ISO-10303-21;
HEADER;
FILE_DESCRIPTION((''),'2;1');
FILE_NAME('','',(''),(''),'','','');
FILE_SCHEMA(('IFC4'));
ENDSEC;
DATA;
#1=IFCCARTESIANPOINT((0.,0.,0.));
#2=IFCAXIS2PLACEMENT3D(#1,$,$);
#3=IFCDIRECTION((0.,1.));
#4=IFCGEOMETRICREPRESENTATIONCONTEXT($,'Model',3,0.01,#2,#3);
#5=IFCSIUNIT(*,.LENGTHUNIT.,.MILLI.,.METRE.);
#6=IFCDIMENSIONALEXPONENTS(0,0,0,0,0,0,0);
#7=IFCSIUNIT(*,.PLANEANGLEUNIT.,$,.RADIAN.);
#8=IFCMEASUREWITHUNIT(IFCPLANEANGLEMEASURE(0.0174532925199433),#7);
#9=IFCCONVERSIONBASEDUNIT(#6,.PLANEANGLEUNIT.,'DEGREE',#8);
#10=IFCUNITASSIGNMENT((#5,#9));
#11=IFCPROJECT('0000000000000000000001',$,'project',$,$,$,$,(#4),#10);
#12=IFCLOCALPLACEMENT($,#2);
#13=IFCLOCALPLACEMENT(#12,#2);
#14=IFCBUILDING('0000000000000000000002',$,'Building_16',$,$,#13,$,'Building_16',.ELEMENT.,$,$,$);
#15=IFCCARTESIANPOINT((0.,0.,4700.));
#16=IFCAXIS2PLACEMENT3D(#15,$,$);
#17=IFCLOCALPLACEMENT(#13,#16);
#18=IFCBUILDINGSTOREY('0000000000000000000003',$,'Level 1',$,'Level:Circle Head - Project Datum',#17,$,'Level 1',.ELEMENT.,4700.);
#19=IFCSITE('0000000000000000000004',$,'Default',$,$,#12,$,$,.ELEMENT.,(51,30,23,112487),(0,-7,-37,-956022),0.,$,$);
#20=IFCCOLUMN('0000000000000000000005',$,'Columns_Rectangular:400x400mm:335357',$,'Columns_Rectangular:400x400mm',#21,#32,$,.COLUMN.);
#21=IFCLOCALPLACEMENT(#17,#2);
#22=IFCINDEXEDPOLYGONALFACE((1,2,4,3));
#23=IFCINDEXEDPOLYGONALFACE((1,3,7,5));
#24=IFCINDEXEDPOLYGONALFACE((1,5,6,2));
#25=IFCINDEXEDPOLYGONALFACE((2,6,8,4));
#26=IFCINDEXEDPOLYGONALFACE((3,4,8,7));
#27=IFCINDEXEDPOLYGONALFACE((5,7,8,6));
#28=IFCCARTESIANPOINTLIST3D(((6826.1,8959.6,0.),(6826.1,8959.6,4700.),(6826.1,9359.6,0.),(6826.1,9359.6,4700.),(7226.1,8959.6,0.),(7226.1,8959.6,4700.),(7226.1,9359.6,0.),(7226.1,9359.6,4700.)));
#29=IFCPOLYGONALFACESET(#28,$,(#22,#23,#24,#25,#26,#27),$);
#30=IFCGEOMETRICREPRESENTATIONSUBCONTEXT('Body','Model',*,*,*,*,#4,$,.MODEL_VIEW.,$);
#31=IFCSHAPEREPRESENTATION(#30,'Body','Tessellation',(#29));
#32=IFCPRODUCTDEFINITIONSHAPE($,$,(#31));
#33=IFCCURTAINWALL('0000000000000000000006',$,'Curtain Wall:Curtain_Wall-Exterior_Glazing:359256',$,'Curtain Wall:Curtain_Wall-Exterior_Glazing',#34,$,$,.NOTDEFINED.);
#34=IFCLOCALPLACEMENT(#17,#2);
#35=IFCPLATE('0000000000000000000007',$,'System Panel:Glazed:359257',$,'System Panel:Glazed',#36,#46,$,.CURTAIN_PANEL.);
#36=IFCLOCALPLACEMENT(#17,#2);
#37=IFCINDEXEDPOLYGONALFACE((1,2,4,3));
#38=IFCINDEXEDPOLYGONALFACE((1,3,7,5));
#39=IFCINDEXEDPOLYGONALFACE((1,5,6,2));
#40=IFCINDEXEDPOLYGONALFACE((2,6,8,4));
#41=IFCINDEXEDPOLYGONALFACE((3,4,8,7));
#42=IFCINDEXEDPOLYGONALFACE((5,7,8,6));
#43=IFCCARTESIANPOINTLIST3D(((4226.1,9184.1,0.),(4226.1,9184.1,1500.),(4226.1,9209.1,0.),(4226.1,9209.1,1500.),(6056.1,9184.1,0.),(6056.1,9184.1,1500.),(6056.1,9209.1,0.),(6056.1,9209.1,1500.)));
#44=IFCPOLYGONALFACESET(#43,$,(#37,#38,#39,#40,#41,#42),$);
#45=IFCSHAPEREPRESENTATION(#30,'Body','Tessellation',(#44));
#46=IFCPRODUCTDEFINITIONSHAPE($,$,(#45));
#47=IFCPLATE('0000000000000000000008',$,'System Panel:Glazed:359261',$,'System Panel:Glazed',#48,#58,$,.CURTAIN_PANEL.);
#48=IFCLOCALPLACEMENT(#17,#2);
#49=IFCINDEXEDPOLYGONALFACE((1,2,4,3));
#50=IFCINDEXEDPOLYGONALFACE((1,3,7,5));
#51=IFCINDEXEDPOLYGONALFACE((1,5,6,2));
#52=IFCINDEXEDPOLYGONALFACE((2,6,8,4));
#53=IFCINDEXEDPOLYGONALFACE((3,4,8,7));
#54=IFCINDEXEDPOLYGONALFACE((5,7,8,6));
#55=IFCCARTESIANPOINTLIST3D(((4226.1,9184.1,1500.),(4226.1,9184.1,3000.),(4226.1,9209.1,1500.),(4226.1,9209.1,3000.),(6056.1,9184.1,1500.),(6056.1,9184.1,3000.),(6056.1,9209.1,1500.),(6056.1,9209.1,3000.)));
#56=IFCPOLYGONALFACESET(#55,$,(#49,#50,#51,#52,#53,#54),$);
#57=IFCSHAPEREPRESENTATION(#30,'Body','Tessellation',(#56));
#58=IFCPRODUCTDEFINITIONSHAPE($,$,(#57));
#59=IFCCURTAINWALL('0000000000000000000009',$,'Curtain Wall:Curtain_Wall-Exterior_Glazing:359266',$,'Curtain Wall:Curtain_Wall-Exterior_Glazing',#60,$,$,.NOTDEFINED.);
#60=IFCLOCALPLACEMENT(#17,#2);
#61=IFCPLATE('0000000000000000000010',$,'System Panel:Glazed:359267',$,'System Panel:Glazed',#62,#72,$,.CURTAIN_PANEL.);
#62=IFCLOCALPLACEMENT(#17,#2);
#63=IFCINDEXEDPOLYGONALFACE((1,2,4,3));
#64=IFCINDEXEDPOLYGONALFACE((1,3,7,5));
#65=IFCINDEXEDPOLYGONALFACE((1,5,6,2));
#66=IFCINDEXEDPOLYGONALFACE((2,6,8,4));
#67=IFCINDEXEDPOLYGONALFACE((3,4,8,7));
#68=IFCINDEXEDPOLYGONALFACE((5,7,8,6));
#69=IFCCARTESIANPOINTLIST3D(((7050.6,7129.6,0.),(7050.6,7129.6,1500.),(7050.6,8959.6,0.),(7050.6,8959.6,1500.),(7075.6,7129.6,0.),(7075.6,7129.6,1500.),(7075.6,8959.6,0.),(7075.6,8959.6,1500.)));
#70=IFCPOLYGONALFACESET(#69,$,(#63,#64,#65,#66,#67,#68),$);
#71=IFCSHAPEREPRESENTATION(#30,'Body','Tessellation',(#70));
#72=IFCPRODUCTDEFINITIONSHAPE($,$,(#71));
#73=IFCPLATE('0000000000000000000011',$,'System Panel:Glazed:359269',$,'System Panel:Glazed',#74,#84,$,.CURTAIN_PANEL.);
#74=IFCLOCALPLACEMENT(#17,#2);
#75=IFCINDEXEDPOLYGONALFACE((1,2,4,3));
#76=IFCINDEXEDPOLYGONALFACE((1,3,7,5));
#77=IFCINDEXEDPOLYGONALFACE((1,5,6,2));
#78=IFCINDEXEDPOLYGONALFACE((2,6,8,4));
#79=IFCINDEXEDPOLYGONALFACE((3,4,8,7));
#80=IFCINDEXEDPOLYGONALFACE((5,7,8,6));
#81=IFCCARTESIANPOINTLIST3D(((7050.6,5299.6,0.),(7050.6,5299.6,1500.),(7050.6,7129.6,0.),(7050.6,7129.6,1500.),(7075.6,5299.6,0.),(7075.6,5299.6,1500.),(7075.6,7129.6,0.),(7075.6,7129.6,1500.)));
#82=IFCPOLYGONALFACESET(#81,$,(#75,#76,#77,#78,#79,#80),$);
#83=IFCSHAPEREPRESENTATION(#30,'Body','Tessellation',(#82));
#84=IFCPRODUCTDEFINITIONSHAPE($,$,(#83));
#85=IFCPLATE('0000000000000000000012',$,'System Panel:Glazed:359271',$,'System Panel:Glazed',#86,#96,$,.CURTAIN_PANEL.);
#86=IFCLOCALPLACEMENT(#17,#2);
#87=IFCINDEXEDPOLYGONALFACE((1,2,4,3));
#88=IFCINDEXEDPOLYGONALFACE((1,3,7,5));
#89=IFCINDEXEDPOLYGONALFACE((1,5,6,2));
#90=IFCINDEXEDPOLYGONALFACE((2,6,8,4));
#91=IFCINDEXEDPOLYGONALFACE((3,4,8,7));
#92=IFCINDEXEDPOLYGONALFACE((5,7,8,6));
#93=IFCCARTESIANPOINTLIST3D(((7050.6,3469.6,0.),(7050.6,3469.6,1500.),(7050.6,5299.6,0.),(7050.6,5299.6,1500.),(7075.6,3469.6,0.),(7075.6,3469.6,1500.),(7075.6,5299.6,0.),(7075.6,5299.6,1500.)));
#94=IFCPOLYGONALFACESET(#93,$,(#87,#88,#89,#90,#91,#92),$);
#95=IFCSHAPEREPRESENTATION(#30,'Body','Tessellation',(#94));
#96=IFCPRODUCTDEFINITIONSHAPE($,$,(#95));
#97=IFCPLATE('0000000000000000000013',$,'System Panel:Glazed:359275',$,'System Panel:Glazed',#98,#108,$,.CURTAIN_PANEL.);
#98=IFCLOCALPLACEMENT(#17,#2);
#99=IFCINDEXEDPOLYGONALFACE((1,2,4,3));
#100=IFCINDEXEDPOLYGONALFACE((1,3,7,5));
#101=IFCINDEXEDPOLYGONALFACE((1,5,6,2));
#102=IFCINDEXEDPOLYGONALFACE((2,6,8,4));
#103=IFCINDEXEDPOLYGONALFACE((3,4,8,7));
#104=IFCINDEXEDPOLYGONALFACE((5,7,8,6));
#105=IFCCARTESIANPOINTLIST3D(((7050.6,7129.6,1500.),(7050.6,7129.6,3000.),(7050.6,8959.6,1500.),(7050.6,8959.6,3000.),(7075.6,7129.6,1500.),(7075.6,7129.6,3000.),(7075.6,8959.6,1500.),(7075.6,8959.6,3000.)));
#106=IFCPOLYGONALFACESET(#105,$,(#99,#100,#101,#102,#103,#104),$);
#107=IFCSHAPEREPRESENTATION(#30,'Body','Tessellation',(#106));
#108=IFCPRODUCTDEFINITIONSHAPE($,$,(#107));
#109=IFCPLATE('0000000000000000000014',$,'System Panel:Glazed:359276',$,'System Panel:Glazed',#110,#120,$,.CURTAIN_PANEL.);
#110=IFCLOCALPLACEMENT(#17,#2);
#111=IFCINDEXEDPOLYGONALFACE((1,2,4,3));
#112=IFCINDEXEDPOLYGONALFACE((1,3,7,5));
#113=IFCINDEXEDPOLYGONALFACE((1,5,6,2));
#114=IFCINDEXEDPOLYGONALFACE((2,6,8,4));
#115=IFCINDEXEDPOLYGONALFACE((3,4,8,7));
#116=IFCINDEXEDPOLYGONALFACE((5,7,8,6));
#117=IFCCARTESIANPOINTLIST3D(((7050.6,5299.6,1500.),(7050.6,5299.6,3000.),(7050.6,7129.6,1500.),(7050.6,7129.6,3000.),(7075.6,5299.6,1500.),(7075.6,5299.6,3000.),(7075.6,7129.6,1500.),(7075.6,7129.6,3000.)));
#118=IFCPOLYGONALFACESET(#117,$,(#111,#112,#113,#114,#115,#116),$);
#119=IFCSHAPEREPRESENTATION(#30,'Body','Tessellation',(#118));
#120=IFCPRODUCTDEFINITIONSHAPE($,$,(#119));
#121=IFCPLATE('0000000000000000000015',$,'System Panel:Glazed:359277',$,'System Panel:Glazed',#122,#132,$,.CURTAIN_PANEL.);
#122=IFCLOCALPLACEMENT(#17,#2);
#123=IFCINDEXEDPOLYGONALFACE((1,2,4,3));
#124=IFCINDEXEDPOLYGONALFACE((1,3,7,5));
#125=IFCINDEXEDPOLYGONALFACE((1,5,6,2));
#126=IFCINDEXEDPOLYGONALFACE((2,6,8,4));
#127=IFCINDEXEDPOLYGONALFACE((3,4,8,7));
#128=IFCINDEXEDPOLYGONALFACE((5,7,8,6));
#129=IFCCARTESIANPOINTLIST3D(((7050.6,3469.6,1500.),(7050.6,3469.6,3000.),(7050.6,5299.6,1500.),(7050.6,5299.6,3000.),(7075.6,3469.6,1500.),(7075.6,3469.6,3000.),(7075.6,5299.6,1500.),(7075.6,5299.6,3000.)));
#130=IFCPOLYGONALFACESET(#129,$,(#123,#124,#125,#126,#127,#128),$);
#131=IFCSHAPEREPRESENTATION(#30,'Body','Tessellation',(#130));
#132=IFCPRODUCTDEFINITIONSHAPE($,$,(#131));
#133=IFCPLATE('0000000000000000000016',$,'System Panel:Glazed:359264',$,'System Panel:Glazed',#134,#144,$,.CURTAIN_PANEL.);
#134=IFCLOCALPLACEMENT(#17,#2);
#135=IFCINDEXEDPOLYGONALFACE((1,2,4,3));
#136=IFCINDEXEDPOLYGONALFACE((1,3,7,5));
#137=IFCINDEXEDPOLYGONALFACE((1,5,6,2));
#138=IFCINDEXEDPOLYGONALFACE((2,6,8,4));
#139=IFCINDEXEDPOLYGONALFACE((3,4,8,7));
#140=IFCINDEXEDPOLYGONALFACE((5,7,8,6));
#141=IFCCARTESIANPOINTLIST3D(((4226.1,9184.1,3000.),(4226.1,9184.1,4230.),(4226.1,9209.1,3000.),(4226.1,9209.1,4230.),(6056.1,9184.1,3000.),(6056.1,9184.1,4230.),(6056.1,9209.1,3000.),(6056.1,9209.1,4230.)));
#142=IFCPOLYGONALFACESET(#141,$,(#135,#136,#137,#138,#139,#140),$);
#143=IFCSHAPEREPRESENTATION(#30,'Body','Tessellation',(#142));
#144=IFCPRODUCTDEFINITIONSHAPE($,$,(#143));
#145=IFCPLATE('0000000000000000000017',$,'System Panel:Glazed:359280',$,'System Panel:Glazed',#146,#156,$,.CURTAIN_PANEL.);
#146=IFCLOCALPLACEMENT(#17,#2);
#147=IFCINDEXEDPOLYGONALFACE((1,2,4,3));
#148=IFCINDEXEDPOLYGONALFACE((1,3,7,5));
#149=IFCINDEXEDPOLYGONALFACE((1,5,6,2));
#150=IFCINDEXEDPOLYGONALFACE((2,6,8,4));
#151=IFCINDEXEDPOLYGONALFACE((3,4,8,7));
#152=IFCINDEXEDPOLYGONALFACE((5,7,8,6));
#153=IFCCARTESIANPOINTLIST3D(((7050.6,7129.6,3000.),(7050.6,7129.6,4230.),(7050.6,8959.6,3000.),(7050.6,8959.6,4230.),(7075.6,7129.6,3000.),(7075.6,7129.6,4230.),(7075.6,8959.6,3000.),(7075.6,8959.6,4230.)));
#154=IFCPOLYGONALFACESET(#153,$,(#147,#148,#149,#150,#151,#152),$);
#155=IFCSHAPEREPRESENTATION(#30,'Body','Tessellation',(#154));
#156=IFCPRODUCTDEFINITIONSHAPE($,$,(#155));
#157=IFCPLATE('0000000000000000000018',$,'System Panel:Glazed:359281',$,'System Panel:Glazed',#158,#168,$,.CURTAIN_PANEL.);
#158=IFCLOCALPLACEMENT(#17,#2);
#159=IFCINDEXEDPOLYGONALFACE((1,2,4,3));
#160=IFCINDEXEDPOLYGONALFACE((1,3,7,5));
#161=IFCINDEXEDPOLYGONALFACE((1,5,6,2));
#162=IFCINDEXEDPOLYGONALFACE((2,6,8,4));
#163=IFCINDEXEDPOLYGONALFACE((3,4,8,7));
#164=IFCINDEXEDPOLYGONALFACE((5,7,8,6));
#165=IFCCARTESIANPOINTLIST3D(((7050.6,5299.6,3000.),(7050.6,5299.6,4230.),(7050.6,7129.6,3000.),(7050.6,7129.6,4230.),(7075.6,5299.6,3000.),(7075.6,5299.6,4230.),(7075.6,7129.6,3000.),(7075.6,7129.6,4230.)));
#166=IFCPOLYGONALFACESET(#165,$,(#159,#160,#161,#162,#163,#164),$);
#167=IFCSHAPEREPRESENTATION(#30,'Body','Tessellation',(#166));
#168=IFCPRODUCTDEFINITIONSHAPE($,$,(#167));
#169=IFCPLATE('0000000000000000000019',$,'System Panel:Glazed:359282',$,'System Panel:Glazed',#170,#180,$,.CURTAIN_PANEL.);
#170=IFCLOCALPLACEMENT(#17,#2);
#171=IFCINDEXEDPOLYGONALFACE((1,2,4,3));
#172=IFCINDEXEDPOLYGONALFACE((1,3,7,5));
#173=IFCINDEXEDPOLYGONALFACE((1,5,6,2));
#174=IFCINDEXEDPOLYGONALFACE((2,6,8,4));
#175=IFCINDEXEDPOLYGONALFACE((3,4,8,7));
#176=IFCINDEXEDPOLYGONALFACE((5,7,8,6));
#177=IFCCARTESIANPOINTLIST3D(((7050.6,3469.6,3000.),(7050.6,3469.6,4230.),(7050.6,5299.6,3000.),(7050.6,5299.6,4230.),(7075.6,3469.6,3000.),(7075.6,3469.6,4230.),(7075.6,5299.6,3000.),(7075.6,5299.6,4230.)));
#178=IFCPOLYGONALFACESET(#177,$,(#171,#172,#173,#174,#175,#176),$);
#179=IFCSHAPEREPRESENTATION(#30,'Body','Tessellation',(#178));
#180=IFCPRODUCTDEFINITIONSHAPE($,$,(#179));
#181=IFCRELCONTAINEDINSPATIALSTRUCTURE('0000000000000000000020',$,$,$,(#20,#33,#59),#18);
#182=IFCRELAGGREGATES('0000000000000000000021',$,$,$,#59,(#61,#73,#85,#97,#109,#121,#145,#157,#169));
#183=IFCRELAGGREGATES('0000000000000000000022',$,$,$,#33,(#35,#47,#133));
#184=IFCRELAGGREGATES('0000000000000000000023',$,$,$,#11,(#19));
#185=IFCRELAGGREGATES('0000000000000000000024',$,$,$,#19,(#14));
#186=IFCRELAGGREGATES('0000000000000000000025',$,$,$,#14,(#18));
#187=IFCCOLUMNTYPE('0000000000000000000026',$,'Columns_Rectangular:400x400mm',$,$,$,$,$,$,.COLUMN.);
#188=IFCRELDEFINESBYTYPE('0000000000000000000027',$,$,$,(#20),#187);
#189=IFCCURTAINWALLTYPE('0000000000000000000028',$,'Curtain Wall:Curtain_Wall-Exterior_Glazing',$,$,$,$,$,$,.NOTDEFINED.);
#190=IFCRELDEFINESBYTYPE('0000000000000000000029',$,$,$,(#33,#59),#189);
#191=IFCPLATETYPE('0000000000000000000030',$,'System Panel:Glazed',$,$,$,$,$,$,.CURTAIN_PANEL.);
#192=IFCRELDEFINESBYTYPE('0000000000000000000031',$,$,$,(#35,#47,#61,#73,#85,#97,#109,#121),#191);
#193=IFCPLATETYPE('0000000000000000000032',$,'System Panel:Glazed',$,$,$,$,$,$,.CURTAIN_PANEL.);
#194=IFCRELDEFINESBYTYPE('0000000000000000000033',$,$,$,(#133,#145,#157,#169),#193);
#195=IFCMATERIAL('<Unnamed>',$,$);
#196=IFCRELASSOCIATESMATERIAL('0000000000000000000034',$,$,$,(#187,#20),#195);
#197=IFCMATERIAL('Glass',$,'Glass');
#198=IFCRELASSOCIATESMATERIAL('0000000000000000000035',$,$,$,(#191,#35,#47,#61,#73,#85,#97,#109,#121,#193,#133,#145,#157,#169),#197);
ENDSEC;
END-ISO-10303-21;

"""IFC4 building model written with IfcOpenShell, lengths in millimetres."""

from ifc_helpers import new_model, entity, si_unit, converted_unit, direction, frame, origin, place, context, subcontext, project, spatial, indexed_curve, outline, extrude, source, transform, mapped, material, type_object, type_shapes, element, aggregate, save


model = new_model("IFC4")

# Units and contexts
model_context = context("Model", 3, precision=0.01, world=origin(), true_north=direction((0.0, 1.0)))
body_context = subcontext(model_context, "Body", "Model", "MODEL_VIEW")
ifc_project = project(units=[si_unit("LENGTHUNIT", "METRE", prefix="MILLI"), converted_unit("PLANEANGLEUNIT", "DEGREE", entity("IfcPlaneAngleMeasure", 0.0174532925199433), si_unit("PLANEANGLEUNIT", "RADIAN"), dimensions=[0, 0, 0, 0, 0, 0, 0])], contexts=[model_context])

# Site, building, storey
site_placement = place(None, origin())
site = spatial("IfcSite", under=ifc_project, at=site_placement, Name="Default", CompositionType="ELEMENT", RefLatitude=(51, 30, 23, 112487), RefLongitude=(0, -7, -37, -956022), RefElevation=0.0)
building_placement = place(site_placement, origin())
building = spatial("IfcBuilding", under=site, at=building_placement, Name="Building_16", LongName="Building_16", CompositionType="ELEMENT")
storey_placement = place(building_placement, frame((0.0, 0.0, 4700.0)))
storey = spatial("IfcBuildingStorey", under=building, at=storey_placement, Name="Level 1", ObjectType="Level:Circle Head - Project Datum", LongName="Level 1", CompositionType="ELEMENT", Elevation=4700.0)

# Column
ifc_material_1 = material(Name="<Unnamed>")
column_type = type_object("IfcColumnType", Name="Columns_Rectangular:400x400mm", PredefinedType="COLUMN", material=ifc_material_1)
shared_shape_1 = source(origin(), body_context, "Body", "SweptSolid", [
    extrude(outline(indexed_curve([(-200.0, -200.0), (200.0, -200.0), (200.0, 200.0), (-200.0, 200.0), (-200.0, -200.0)], self_intersect=False)), frame((0.0, 0.0, 4700.0), z_axis=(0.0, 0.0, 1.0), x_axis=(-1.0, 0.0, 0.0)), (0.0, 0.0, 1.0), 4700.0),
])
type_shapes(column_type, [shared_shape_1])
column_placement = place(storey_placement, frame((7026.1, 9159.6, -4700.0)))
element("IfcColumn", 1, at=column_placement, inside=storey, type_object=column_type, material=ifc_material_1, Name="Columns_Rectangular:400x400mm:335357", ObjectType="Columns_Rectangular:400x400mm", PredefinedType="COLUMN", context=body_context, shape_type="MappedRepresentation", body=[
    mapped(shared_shape_1, transform((0.0, 0.0, 0.0), scale=1.0)),
])

# Curtain walls, plates
curtain_wall_type = type_object("IfcCurtainWallType", Name="Curtain Wall:Curtain_Wall-Exterior_Glazing", PredefinedType="NOTDEFINED")
curtain_wall_1_placement = place(storey_placement, frame((0.0, 0.0, -4700.0)))
curtain_wall_1 = element("IfcCurtainWall", 2, at=curtain_wall_1_placement, inside=storey, type_object=curtain_wall_type, Name="Curtain Wall:Curtain_Wall-Exterior_Glazing:359256", ObjectType="Curtain Wall:Curtain_Wall-Exterior_Glazing", PredefinedType="NOTDEFINED")
ifc_material_2 = material(Name="Glass", Category="Glass")
plate_type_1 = type_object("IfcPlateType", Name="System Panel:Glazed", PredefinedType="CURTAIN_PANEL", material=ifc_material_2)
shared_shape_2 = source(origin(), body_context, "Body", "SweptSolid", [
    extrude(outline(indexed_curve([(-12.5, -915.0), (12.5, -915.0), (12.5, 915.0), (-12.5, 915.0), (-12.5, -915.0)], self_intersect=False)), frame((0.0, 37.0, 0.0), z_axis=(0.0, 0.0, 1.0), x_axis=(0.0, 1.0, 0.0)), (0.0, 0.0, 1.0), 1500.0),
])
type_shapes(plate_type_1, [shared_shape_2])
plate_1_placement = place(curtain_wall_1_placement, frame((5141.1, 9159.6, 4700.0)))
plate_1 = element("IfcPlate", 3, at=plate_1_placement, type_object=plate_type_1, material=ifc_material_2, Name="System Panel:Glazed:359257", ObjectType="System Panel:Glazed", PredefinedType="CURTAIN_PANEL", context=body_context, shape_type="MappedRepresentation", body=[
    mapped(shared_shape_2, transform((0.0, 0.0, 0.0), scale=1.0)),
])
plate_2_placement = place(curtain_wall_1_placement, frame((5141.1, 9159.6, 6200.0)))
plate_2 = element("IfcPlate", 4, at=plate_2_placement, type_object=plate_type_1, material=ifc_material_2, Name="System Panel:Glazed:359261", ObjectType="System Panel:Glazed", PredefinedType="CURTAIN_PANEL", context=body_context, shape_type="MappedRepresentation", body=[
    mapped(shared_shape_2, transform((0.0, 0.0, 0.0), scale=1.0)),
])
curtain_wall_2_placement = place(storey_placement, frame((0.0, 0.0, -4700.0)))
curtain_wall_2 = element("IfcCurtainWall", 5, at=curtain_wall_2_placement, inside=storey, type_object=curtain_wall_type, Name="Curtain Wall:Curtain_Wall-Exterior_Glazing:359266", ObjectType="Curtain Wall:Curtain_Wall-Exterior_Glazing", PredefinedType="NOTDEFINED")
plate_3_placement = place(curtain_wall_2_placement, frame((7026.1, 8044.6, 4700.0), z_axis=(0.0, 0.0, 1.0), x_axis=(0.0, -1.0, 0.0)))
plate_3 = element("IfcPlate", 6, at=plate_3_placement, type_object=plate_type_1, material=ifc_material_2, Name="System Panel:Glazed:359267", ObjectType="System Panel:Glazed", PredefinedType="CURTAIN_PANEL", context=body_context, shape_type="MappedRepresentation", body=[
    mapped(shared_shape_2, transform((0.0, 0.0, 0.0), scale=1.0)),
])
plate_4_placement = place(curtain_wall_2_placement, frame((7026.1, 6214.6, 4700.0), z_axis=(0.0, 0.0, 1.0), x_axis=(0.0, -1.0, 0.0)))
plate_4 = element("IfcPlate", 7, at=plate_4_placement, type_object=plate_type_1, material=ifc_material_2, Name="System Panel:Glazed:359269", ObjectType="System Panel:Glazed", PredefinedType="CURTAIN_PANEL", context=body_context, shape_type="MappedRepresentation", body=[
    mapped(shared_shape_2, transform((0.0, 0.0, 0.0), scale=1.0)),
])
plate_5_placement = place(curtain_wall_2_placement, frame((7026.1, 4384.6, 4700.0), z_axis=(0.0, 0.0, 1.0), x_axis=(0.0, -1.0, 0.0)))
plate_5 = element("IfcPlate", 8, at=plate_5_placement, type_object=plate_type_1, material=ifc_material_2, Name="System Panel:Glazed:359271", ObjectType="System Panel:Glazed", PredefinedType="CURTAIN_PANEL", context=body_context, shape_type="MappedRepresentation", body=[
    mapped(shared_shape_2, transform((0.0, 0.0, 0.0), scale=1.0)),
])
plate_6_placement = place(curtain_wall_2_placement, frame((7026.1, 8044.6, 6200.0), z_axis=(0.0, 0.0, 1.0), x_axis=(0.0, -1.0, 0.0)))
plate_6 = element("IfcPlate", 9, at=plate_6_placement, type_object=plate_type_1, material=ifc_material_2, Name="System Panel:Glazed:359275", ObjectType="System Panel:Glazed", PredefinedType="CURTAIN_PANEL", context=body_context, shape_type="MappedRepresentation", body=[
    mapped(shared_shape_2, transform((0.0, 0.0, 0.0), scale=1.0)),
])
plate_7_placement = place(curtain_wall_2_placement, frame((7026.1, 6214.6, 6200.0), z_axis=(0.0, 0.0, 1.0), x_axis=(0.0, -1.0, 0.0)))
plate_7 = element("IfcPlate", 10, at=plate_7_placement, type_object=plate_type_1, material=ifc_material_2, Name="System Panel:Glazed:359276", ObjectType="System Panel:Glazed", PredefinedType="CURTAIN_PANEL", context=body_context, shape_type="MappedRepresentation", body=[
    mapped(shared_shape_2, transform((0.0, 0.0, 0.0), scale=1.0)),
])
plate_8_placement = place(curtain_wall_2_placement, frame((7026.1, 4384.6, 6200.0), z_axis=(0.0, 0.0, 1.0), x_axis=(0.0, -1.0, 0.0)))
plate_8 = element("IfcPlate", 11, at=plate_8_placement, type_object=plate_type_1, material=ifc_material_2, Name="System Panel:Glazed:359277", ObjectType="System Panel:Glazed", PredefinedType="CURTAIN_PANEL", context=body_context, shape_type="MappedRepresentation", body=[
    mapped(shared_shape_2, transform((0.0, 0.0, 0.0), scale=1.0)),
])

# Plates
plate_type_2 = type_object("IfcPlateType", Name="System Panel:Glazed", PredefinedType="CURTAIN_PANEL", material=ifc_material_2)
shared_shape_3 = source(origin(), body_context, "Body", "SweptSolid", [
    extrude(outline(indexed_curve([(-12.5, -915.0), (12.5, -915.0), (12.5, 915.0), (-12.5, 915.0), (-12.5, -915.0)], self_intersect=False)), frame((0.0, 37.0, 0.0), z_axis=(0.0, 0.0, 1.0), x_axis=(0.0, 1.0, 0.0)), (0.0, 0.0, 1.0), 1230.0),
])
type_shapes(plate_type_2, [shared_shape_3])
plate_9_placement = place(curtain_wall_1_placement, frame((5141.1, 9159.6, 7700.0)))
plate_9 = element("IfcPlate", 12, at=plate_9_placement, type_object=plate_type_2, material=ifc_material_2, Name="System Panel:Glazed:359264", ObjectType="System Panel:Glazed", PredefinedType="CURTAIN_PANEL", context=body_context, shape_type="MappedRepresentation", body=[
    mapped(shared_shape_3, transform((0.0, 0.0, 0.0), scale=1.0)),
])
plate_10_placement = place(curtain_wall_2_placement, frame((7026.1, 8044.6, 7700.0), z_axis=(0.0, 0.0, 1.0), x_axis=(0.0, -1.0, 0.0)))
plate_10 = element("IfcPlate", 13, at=plate_10_placement, type_object=plate_type_2, material=ifc_material_2, Name="System Panel:Glazed:359280", ObjectType="System Panel:Glazed", PredefinedType="CURTAIN_PANEL", context=body_context, shape_type="MappedRepresentation", body=[
    mapped(shared_shape_3, transform((0.0, 0.0, 0.0), scale=1.0)),
])
plate_11_placement = place(curtain_wall_2_placement, frame((7026.1, 6214.6, 7700.0), z_axis=(0.0, 0.0, 1.0), x_axis=(0.0, -1.0, 0.0)))
plate_11 = element("IfcPlate", 14, at=plate_11_placement, type_object=plate_type_2, material=ifc_material_2, Name="System Panel:Glazed:359281", ObjectType="System Panel:Glazed", PredefinedType="CURTAIN_PANEL", context=body_context, shape_type="MappedRepresentation", body=[
    mapped(shared_shape_3, transform((0.0, 0.0, 0.0), scale=1.0)),
])
plate_12_placement = place(curtain_wall_2_placement, frame((7026.1, 4384.6, 7700.0), z_axis=(0.0, 0.0, 1.0), x_axis=(0.0, -1.0, 0.0)))
plate_12 = element("IfcPlate", 15, at=plate_12_placement, type_object=plate_type_2, material=ifc_material_2, Name="System Panel:Glazed:359282", ObjectType="System Panel:Glazed", PredefinedType="CURTAIN_PANEL", context=body_context, shape_type="MappedRepresentation", body=[
    mapped(shared_shape_3, transform((0.0, 0.0, 0.0), scale=1.0)),
])
aggregate(curtain_wall_2, [plate_3, plate_4, plate_5, plate_6, plate_7, plate_8, plate_10, plate_11, plate_12])

aggregate(curtain_wall_1, [plate_1, plate_2, plate_9])

save(model, "model.ifc")
